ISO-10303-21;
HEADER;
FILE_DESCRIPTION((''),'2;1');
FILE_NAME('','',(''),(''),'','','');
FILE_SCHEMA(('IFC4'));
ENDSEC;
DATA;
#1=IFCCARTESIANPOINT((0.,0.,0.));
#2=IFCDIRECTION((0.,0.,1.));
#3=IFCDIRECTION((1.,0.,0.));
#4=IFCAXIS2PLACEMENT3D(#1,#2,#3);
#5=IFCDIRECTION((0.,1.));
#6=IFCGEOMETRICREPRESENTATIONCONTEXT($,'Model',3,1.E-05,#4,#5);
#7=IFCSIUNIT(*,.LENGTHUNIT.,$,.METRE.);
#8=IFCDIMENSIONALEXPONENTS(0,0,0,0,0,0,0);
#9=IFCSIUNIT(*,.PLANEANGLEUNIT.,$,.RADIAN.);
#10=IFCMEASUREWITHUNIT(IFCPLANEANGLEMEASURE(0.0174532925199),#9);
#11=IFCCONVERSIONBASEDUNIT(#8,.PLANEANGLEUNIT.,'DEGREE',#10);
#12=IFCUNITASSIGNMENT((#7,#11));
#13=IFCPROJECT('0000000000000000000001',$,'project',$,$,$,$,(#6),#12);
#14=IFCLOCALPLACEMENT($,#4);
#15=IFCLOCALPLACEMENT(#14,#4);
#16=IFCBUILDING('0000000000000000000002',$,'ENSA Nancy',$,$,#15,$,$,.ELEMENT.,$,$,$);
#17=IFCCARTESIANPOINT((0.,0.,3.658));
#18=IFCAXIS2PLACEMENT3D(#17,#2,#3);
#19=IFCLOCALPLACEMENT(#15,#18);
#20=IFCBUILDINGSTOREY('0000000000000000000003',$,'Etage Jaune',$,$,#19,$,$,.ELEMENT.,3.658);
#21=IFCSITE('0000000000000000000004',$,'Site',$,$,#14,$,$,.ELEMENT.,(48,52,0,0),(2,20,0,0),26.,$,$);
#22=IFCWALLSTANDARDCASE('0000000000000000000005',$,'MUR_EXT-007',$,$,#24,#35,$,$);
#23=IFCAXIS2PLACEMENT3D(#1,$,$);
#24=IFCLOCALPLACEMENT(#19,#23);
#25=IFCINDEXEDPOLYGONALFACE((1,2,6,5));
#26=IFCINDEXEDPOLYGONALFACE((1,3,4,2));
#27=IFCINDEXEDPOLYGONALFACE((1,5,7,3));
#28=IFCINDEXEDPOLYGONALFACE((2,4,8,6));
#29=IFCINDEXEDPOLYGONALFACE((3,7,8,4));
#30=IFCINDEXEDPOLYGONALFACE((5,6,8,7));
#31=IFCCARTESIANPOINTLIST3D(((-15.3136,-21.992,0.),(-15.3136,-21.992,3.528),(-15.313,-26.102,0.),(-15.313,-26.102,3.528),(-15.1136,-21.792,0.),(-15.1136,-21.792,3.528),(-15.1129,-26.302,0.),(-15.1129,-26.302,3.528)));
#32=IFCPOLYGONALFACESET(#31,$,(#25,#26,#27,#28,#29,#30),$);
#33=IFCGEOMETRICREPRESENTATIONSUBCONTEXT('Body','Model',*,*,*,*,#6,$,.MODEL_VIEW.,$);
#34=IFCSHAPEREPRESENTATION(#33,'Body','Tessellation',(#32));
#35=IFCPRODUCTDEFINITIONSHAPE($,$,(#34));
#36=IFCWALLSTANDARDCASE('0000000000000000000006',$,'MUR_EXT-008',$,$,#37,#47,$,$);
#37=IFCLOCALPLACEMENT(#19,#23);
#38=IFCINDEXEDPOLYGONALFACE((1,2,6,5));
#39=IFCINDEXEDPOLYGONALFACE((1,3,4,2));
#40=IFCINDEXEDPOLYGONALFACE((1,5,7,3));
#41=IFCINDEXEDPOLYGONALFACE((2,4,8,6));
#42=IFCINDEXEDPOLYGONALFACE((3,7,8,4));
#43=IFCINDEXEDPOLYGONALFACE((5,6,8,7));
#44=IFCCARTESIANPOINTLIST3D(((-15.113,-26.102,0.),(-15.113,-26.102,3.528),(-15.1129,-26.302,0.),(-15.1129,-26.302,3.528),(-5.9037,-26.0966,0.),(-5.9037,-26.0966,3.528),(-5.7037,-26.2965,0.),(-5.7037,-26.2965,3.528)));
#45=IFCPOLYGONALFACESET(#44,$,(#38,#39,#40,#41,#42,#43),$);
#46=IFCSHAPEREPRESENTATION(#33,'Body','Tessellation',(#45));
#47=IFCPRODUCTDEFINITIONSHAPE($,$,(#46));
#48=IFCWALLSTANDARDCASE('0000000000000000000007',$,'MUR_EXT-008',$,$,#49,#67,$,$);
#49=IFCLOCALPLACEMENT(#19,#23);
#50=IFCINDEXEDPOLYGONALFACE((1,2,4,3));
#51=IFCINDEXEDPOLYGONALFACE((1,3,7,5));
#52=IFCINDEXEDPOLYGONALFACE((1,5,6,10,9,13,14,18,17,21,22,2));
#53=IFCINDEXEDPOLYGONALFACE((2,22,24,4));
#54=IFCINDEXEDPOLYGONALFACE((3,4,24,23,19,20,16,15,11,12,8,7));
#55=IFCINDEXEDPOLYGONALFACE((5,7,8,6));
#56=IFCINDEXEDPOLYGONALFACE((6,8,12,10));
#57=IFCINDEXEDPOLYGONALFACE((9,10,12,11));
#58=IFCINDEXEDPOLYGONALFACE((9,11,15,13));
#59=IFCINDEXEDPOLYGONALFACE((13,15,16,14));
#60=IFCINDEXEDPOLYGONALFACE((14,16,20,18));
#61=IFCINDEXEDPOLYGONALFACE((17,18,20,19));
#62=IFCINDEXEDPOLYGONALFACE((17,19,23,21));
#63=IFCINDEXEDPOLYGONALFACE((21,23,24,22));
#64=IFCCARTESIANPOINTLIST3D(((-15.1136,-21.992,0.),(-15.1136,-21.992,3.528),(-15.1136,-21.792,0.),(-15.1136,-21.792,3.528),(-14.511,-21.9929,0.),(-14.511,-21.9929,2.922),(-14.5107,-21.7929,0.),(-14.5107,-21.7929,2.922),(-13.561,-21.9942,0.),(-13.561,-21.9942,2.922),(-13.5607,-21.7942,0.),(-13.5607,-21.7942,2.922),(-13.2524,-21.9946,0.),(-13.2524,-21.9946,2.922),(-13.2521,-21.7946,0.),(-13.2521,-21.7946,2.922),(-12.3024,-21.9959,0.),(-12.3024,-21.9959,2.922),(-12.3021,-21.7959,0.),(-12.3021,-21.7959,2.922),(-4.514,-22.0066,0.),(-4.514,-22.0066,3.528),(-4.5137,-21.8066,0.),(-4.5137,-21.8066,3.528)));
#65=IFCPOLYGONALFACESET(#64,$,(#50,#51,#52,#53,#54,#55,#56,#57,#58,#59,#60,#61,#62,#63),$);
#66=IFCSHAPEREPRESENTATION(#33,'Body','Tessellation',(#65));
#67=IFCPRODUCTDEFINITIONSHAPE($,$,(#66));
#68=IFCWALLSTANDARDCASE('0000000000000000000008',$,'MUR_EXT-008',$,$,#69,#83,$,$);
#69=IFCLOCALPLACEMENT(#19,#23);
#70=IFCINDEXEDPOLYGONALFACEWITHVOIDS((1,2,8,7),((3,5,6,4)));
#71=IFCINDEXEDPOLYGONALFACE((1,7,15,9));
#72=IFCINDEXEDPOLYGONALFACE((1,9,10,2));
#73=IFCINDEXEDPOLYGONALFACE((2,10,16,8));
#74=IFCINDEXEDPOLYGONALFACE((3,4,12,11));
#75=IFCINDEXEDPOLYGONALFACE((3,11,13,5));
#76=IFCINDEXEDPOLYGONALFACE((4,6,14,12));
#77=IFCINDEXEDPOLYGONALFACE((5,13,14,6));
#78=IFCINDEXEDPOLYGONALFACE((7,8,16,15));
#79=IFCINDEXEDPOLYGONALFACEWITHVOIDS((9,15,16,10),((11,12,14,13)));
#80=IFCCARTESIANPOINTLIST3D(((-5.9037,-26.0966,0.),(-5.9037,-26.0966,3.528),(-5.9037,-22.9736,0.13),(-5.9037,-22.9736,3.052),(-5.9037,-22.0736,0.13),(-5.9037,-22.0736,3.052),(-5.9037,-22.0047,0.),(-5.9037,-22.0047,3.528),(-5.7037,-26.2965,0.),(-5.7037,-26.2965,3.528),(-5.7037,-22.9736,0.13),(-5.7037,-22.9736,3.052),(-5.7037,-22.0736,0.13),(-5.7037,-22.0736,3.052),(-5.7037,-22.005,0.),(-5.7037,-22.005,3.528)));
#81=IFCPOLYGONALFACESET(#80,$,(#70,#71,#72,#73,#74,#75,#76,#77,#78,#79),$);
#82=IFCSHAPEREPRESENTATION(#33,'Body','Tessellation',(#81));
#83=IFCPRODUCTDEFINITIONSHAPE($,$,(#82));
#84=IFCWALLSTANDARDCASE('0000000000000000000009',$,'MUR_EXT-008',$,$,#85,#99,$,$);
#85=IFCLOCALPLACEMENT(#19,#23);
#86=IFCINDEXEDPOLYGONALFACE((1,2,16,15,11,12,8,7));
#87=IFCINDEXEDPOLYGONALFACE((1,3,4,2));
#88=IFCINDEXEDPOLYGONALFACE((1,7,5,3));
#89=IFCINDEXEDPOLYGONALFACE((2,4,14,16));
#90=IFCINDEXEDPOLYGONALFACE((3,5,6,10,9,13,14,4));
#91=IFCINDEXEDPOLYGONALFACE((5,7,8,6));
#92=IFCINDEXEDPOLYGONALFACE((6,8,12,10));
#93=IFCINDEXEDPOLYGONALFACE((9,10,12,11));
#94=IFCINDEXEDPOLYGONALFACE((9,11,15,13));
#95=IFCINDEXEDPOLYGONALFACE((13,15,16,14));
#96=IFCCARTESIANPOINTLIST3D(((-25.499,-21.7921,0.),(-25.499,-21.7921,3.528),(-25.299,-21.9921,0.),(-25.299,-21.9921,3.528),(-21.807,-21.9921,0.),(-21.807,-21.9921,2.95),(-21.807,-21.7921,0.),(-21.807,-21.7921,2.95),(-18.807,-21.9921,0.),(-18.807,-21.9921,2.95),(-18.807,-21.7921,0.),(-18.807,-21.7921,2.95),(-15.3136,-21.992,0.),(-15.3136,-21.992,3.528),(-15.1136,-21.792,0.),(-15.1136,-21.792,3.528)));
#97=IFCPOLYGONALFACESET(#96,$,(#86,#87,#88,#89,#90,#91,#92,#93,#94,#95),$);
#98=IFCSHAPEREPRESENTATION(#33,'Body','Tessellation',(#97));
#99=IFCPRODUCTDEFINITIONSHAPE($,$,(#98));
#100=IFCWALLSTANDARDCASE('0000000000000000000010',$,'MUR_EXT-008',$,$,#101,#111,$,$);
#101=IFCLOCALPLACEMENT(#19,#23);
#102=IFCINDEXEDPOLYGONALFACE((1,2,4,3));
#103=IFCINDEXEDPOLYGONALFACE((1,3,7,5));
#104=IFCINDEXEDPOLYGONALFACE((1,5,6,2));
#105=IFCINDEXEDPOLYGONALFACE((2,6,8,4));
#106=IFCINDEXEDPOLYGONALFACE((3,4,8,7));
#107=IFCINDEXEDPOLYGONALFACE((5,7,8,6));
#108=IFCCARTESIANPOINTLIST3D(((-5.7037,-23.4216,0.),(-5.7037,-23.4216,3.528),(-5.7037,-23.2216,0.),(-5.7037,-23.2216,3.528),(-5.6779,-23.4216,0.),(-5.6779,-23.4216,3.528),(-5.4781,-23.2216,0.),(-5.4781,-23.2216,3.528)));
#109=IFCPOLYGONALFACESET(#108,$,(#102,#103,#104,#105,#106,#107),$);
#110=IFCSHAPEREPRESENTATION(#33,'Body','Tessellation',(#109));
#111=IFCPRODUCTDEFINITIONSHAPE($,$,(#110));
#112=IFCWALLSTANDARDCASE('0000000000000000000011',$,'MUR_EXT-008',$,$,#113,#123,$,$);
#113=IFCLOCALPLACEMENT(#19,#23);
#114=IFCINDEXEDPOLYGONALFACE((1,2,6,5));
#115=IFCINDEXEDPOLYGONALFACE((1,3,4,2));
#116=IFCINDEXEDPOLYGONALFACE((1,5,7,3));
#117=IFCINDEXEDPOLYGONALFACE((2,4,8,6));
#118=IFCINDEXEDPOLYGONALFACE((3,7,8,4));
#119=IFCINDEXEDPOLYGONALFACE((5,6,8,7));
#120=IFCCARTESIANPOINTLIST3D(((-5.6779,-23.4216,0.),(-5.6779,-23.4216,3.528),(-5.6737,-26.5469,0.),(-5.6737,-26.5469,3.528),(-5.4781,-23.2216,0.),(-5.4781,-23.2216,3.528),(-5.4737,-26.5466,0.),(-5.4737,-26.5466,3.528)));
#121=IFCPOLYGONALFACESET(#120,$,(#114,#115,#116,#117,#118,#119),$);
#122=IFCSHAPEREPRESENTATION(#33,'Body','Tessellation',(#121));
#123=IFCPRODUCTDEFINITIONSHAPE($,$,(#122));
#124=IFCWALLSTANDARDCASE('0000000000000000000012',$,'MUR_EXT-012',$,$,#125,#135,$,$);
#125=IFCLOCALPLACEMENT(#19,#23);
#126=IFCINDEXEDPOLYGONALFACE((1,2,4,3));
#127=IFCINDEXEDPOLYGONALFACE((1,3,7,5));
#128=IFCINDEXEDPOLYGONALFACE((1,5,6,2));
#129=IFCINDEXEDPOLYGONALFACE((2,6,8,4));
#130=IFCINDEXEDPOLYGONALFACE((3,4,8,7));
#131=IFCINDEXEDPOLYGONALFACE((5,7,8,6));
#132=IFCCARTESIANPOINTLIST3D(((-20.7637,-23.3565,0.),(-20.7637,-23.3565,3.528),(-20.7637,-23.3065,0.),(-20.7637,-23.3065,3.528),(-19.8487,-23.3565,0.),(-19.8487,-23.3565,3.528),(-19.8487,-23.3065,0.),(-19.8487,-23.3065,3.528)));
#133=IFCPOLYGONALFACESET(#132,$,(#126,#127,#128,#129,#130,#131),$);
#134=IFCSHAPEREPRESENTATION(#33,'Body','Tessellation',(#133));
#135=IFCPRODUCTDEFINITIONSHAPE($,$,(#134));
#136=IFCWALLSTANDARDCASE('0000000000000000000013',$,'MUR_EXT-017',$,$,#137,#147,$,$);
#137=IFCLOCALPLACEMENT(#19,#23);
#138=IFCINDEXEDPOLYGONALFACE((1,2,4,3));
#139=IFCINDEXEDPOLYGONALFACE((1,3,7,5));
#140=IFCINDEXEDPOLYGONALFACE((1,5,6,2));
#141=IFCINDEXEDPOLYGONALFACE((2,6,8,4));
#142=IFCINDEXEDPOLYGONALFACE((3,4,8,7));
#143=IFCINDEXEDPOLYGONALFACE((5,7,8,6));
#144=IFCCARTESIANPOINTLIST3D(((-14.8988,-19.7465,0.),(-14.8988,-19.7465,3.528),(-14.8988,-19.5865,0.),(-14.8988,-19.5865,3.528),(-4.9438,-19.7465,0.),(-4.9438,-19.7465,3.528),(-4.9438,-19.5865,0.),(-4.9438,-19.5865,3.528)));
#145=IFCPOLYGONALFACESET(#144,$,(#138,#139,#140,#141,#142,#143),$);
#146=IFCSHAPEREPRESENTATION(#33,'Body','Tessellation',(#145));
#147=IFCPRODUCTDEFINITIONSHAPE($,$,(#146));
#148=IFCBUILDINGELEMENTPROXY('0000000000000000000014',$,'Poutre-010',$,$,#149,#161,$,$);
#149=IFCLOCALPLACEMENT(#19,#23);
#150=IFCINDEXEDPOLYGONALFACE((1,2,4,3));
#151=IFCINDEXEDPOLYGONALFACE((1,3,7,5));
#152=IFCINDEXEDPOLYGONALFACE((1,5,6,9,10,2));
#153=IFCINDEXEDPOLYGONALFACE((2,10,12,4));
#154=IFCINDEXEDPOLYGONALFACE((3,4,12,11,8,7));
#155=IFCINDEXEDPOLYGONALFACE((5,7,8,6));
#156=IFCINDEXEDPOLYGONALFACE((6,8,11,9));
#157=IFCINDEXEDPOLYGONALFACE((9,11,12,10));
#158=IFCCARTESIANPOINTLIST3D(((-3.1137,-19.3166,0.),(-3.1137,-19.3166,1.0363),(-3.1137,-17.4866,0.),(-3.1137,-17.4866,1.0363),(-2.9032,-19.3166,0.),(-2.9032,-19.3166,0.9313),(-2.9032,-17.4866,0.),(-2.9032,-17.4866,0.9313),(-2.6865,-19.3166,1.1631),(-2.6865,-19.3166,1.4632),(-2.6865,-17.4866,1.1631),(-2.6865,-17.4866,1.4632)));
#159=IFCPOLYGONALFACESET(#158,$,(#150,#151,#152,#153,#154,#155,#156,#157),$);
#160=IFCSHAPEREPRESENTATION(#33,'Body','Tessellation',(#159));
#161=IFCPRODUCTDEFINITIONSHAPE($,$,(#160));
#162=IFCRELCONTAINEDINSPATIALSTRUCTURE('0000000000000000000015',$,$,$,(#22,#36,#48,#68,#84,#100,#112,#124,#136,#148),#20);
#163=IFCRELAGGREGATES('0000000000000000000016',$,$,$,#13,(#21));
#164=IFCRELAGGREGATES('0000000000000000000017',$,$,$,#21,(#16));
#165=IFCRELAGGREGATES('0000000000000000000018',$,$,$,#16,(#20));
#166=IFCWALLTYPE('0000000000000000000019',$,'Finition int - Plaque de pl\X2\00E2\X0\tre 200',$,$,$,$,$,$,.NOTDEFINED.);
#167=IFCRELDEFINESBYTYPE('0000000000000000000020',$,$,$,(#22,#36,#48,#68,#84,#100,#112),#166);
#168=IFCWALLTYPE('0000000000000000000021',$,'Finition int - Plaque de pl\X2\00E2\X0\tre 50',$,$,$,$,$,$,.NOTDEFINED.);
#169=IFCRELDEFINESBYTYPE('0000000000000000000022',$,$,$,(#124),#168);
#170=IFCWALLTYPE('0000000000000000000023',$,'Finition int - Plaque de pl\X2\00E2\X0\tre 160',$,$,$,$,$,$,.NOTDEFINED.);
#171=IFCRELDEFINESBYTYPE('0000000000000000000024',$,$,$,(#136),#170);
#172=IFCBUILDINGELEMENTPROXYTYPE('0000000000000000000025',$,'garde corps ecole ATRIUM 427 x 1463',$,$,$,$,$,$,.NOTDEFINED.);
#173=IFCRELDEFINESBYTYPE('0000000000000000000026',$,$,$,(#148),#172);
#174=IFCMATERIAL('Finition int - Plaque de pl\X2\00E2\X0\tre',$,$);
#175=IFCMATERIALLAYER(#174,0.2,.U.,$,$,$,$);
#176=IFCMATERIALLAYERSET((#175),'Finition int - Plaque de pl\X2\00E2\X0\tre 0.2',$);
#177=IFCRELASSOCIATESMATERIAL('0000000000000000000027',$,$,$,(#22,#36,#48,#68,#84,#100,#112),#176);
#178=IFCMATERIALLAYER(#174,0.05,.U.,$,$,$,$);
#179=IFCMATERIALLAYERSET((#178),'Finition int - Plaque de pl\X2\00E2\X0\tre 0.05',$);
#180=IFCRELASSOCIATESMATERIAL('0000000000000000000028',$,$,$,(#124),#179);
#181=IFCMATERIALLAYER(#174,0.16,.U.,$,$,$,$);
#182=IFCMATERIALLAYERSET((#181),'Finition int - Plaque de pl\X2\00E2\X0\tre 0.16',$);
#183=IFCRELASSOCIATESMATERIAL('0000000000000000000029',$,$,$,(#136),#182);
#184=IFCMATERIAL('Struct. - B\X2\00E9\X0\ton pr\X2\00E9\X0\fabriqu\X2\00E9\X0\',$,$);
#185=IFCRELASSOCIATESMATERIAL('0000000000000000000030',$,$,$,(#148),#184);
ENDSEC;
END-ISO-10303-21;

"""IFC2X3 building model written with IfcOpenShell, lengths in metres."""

from ifc_helpers import new_model, entity, si_unit, converted_unit, direction, frame, origin_with_axes, origin_2d_with_axis, place, context, subcontext, project, spatial, polyline, rectangle, outline, extrude, material, layer, layer_set, layer_usage, type_object, element, save


model = new_model("IFC2X3")

# Units and contexts
model_context = context("Model", 3, precision=1e-05, world=origin_with_axes(), true_north=direction((0.0, 1.0)))
body_context = subcontext(model_context, "Body", "Model", "MODEL_VIEW")
ifc_project = project(units=[si_unit("LENGTHUNIT", "METRE"), converted_unit("PLANEANGLEUNIT", "DEGREE", entity("IfcPlaneAngleMeasure", 0.0174532925199), si_unit("PLANEANGLEUNIT", "RADIAN"), dimensions=[0, 0, 0, 0, 0, 0, 0])], contexts=[model_context])

# Site, building, storey
site_placement = place(None, origin_with_axes())
site = spatial("IfcSite", under=ifc_project, at=site_placement, Name="Site", CompositionType="ELEMENT", RefLatitude=(48, 52, 0, 0), RefLongitude=(2, 20, 0, 0), RefElevation=26.0)
building_placement = place(site_placement, origin_with_axes())
building = spatial("IfcBuilding", under=site, at=building_placement, Name="ENSA Nancy", CompositionType="ELEMENT")
storey_placement = place(building_placement, frame((0.0, 0.0, 3.658), z_axis=(0.0, 0.0, 1.0), x_axis=(1.0, 0.0, 0.0)))
storey = spatial("IfcBuildingStorey", under=building, at=storey_placement, Name="Etage Jaune", CompositionType="ELEMENT", Elevation=3.658)

# Walls
ifc_material_1 = material(Name="Finition int - Plaque de plâtre")
ifc_layer_1 = layer(ifc_material_1, 0.2, ventilated="UNKNOWN")
ifc_layer_set_1 = layer_set([ifc_layer_1], Name="Finition int - Plaque de plâtre 0.2")
ifc_layer_usage_1 = layer_usage(ifc_layer_set_1, "AXIS2", "POSITIVE", 0.0)
wall_type_1 = type_object("IfcWallType", Name="Finition int - Plaque de plâtre 200", PredefinedType="NOTDEFINED")
wall_1_placement = place(storey_placement, frame((-15.1129, -26.302, 0.0), z_axis=(0.0, 0.0, 1.0), x_axis=(-0.00015, 1.0, 0.0)))
element("IfcWallStandardCase", 1, at=wall_1_placement, inside=storey, type_object=wall_type_1, material=ifc_layer_usage_1, Name="MUR_EXT-007", context=body_context, shape_type="SweptSolid", body=[
    extrude(outline(polyline([(0.0, 0.0), (4.51, 0.0), (4.31, 0.2), (0.2, 0.2), (0.0, 0.0)])), origin_with_axes(), (0.0, 0.0, 1.0), 3.528),
])
ifc_layer_usage_2 = layer_usage(ifc_layer_set_1, "AXIS2", "NEGATIVE", 0.0)
wall_2_placement = place(storey_placement, frame((-5.7037, -26.2965, 0.0), z_axis=(0.0, 0.0, 1.0), x_axis=(-1.0, -0.000589, 0.0)))
element("IfcWallStandardCase", 2, at=wall_2_placement, inside=storey, type_object=wall_type_1, material=ifc_layer_usage_2, Name="MUR_EXT-008", context=body_context, shape_type="SweptSolid", body=[
    extrude(outline(polyline([(0.1999, -0.2), (9.4092, -0.2), (9.4092, 0.0), (0.0, 0.0), (0.1999, -0.2)])), origin_with_axes(), (0.0, 0.0, 1.0), 3.528),
])

# Wall, openings
ifc_layer_usage_3 = layer_usage(ifc_layer_set_1, "AXIS2", "POSITIVE", 0.0)
wall_3_placement = place(storey_placement, frame((-4.5137, -21.8066, 0.0), z_axis=(0.0, 0.0, 1.0), x_axis=(-0.999999, 0.001372, 0.0)))
wall_3 = element("IfcWallStandardCase", 3, at=wall_3_placement, inside=storey, type_object=wall_type_1, material=ifc_layer_usage_3, Name="MUR_EXT-008", context=body_context, shape_type="SweptSolid", body=[
    extrude(outline(polyline([(0.0, 0.0), (10.5999, 0.0), (10.5996, 0.2), (0.0, 0.2), (0.0, 0.0)])), origin_with_axes(), (0.0, 0.0, 1.0), 3.528),
])
opening_1_placement = place(wall_3_placement, frame((8.2634, 0.0, 0.0), z_axis=(0.0, 0.0, 1.0), x_axis=(1.0, 0.0, 0.0)))
element("IfcOpeningElement", 4, at=opening_1_placement, cuts=wall_3, context=body_context, shape_type="SweptSolid", body=[
    extrude(rectangle(XDim=0.95, YDim=2.922, at=origin_2d_with_axis()), frame((0.0, 0.2, 1.461), z_axis=(0.0, 1.0, 0.0), x_axis=(1.0, 0.0, 0.0)), (0.0, 0.0, -1.0), 0.6),
])
opening_2_placement = place(wall_3_placement, frame((9.522, 0.0, 0.0), z_axis=(0.0, 0.0, 1.0), x_axis=(1.0, 0.0, 0.0)))
element("IfcOpeningElement", 5, at=opening_2_placement, cuts=wall_3, context=body_context, shape_type="SweptSolid", body=[
    extrude(rectangle(XDim=0.95, YDim=2.922, at=origin_2d_with_axis()), frame((0.0, 0.2, 1.461), z_axis=(0.0, -1.0, 0.0), x_axis=(-1.0, 0.0, 0.0)), (0.0, 0.0, 1.0), 0.6),
])

# Walls, openings
ifc_layer_usage_4 = layer_usage(ifc_layer_set_1, "AXIS2", "NEGATIVE", 0.0)
wall_4_placement = place(storey_placement, frame((-5.7037, -21.805, 0.0), z_axis=(0.0, 0.0, 1.0), x_axis=(0.0, -1.0, 0.0)))
wall_4 = element("IfcWallStandardCase", 6, at=wall_4_placement, inside=storey, type_object=wall_type_1, material=ifc_layer_usage_4, Name="MUR_EXT-008", context=body_context, shape_type="SweptSolid", body=[
    extrude(outline(polyline([(0.1997, -0.2), (4.2917, -0.2), (4.4915, 0.0), (0.2, 0.0), (0.1997, -0.2)])), origin_with_axes(), (0.0, 0.0, 1.0), 3.528),
])
opening_3_placement = place(wall_4_placement, frame((0.7186, 0.0, 0.13), z_axis=(0.0, 0.0, 1.0), x_axis=(1.0, 0.0, 0.0)))
element("IfcOpeningElement", 7, at=opening_3_placement, cuts=wall_4, context=body_context, shape_type="SweptSolid", body=[
    extrude(rectangle(XDim=0.9, YDim=2.922, at=origin_2d_with_axis()), frame((0.0, -0.2, 1.461), z_axis=(0.0, 1.0, 0.0), x_axis=(-1.0, 0.0, 0.0)), (0.0, 0.0, 1.0), 0.6),
])
ifc_layer_usage_5 = layer_usage(ifc_layer_set_1, "AXIS2", "POSITIVE", 0.0)
wall_5_placement = place(storey_placement, frame((-15.1136, -21.792, 0.0), z_axis=(0.0, 0.0, 1.0), x_axis=(-1.0, -0.000003, 0.0)))
wall_5 = element("IfcWallStandardCase", 8, at=wall_5_placement, inside=storey, type_object=wall_type_1, material=ifc_layer_usage_5, Name="MUR_EXT-008", context=body_context, shape_type="SweptSolid", body=[
    extrude(outline(polyline([(0.0, 0.0), (10.3854, 0.0), (10.1854, 0.2), (0.2, 0.2), (0.0, 0.0)])), origin_with_axes(), (0.0, 0.0, 1.0), 3.528),
])
opening_4_placement = place(wall_5_placement, frame((5.1934, 0.0, 0.0), z_axis=(0.0, 0.0, 1.0), x_axis=(1.0, 0.0, 0.0)))
element("IfcOpeningElement", 9, at=opening_4_placement, cuts=wall_5, context=body_context, shape_type="SweptSolid", body=[
    extrude(rectangle(XDim=3.0, YDim=2.95, at=origin_2d_with_axis()), frame((0.0, 0.2, 1.475), z_axis=(0.0, 1.0, 0.0), x_axis=(-1.0, 0.0, 0.0)), (0.0, 0.0, -1.0), 0.6),
])

# Walls
ifc_layer_usage_6 = layer_usage(ifc_layer_set_1, "AXIS2", "NEGATIVE", 0.0)
wall_6_placement = place(storey_placement, frame((-5.7037, -23.2216, 0.0), z_axis=(0.0, 0.0, 1.0), x_axis=(1.0, 0.0, 0.0)))
element("IfcWallStandardCase", 10, at=wall_6_placement, inside=storey, type_object=wall_type_1, material=ifc_layer_usage_6, Name="MUR_EXT-008", context=body_context, shape_type="SweptSolid", body=[
    extrude(outline(polyline([(0.0, -0.2), (0.0258, -0.2), (0.2255, 0.0), (0.0, 0.0), (0.0, -0.2)])), origin_with_axes(), (0.0, 0.0, 1.0), 3.528),
])
ifc_layer_usage_7 = layer_usage(ifc_layer_set_1, "AXIS2", "NEGATIVE", 0.0)
wall_7_placement = place(storey_placement, frame((-5.4781, -23.2216, 0.0), z_axis=(0.0, 0.0, 1.0), x_axis=(0.001341, -0.999999, 0.0)))
element("IfcWallStandardCase", 11, at=wall_7_placement, inside=storey, type_object=wall_type_1, material=ifc_layer_usage_7, Name="MUR_EXT-008", context=body_context, shape_type="SweptSolid", body=[
    extrude(outline(polyline([(0.1997, -0.2), (3.325, -0.2), (3.325, 0.0), (0.0, 0.0), (0.1997, -0.2)])), origin_with_axes(), (0.0, 0.0, 1.0), 3.528),
])
ifc_layer_2 = layer(ifc_material_1, 0.05, ventilated="UNKNOWN")
ifc_layer_set_2 = layer_set([ifc_layer_2], Name="Finition int - Plaque de plâtre 0.05")
ifc_layer_usage_8 = layer_usage(ifc_layer_set_2, "AXIS2", "POSITIVE", -0.05)
wall_type_2 = type_object("IfcWallType", Name="Finition int - Plaque de plâtre 50", PredefinedType="NOTDEFINED")
wall_8_placement = place(storey_placement, frame((-19.8487, -23.3565, 0.0), z_axis=(0.0, 0.0, 1.0), x_axis=(-1.0, 0.0, 0.0)))
element("IfcWallStandardCase", 12, at=wall_8_placement, inside=storey, type_object=wall_type_2, material=ifc_layer_usage_8, Name="MUR_EXT-012", context=body_context, shape_type="SweptSolid", body=[
    extrude(outline(polyline([(0.0, -0.05), (0.915, -0.05), (0.915, 0.0), (0.0, 0.0), (0.0, -0.05)])), origin_with_axes(), (0.0, 0.0, 1.0), 3.528),
])
ifc_layer_3 = layer(ifc_material_1, 0.16, ventilated="UNKNOWN")
ifc_layer_set_3 = layer_set([ifc_layer_3], Name="Finition int - Plaque de plâtre 0.16")
ifc_layer_usage_9 = layer_usage(ifc_layer_set_3, "AXIS2", "POSITIVE", -0.16)
wall_type_3 = type_object("IfcWallType", Name="Finition int - Plaque de plâtre 160", PredefinedType="NOTDEFINED")
wall_9_placement = place(storey_placement, frame((-14.8988, -19.5865, 0.0), z_axis=(0.0, 0.0, 1.0), x_axis=(1.0, 0.0, 0.0)))
element("IfcWallStandardCase", 13, at=wall_9_placement, inside=storey, type_object=wall_type_3, material=ifc_layer_usage_9, Name="MUR_EXT-017", context=body_context, shape_type="SweptSolid", body=[
    extrude(outline(polyline([(0.0, -0.16), (9.955, -0.16), (9.955, 0.0), (0.0, 0.0), (0.0, -0.16)])), origin_with_axes(), (0.0, 0.0, 1.0), 3.528),
])

# Building element proxy
ifc_material_2 = material(Name="Struct. - Béton préfabriqué")
building_element_proxy_type_1 = type_object("IfcBuildingElementProxyType", Name="garde corps ecole ATRIUM 427 x 1463", PredefinedType="NOTDEFINED")
proxy_1_placement = place(storey_placement, frame((-3.1137, -19.3166, 0.0), z_axis=(0.0, 0.0, 1.0), x_axis=(1.0, 0.0, 0.0)))
element("IfcBuildingElementProxy", 14, at=proxy_1_placement, inside=storey, type_object=building_element_proxy_type_1, material=ifc_material_2, Name="Poutre-010", context=body_context, shape_type="SweptSolid", body=[
    extrude(outline(polyline([(0.0, 1.0363), (0.0, 0.0), (0.2105, 0.0), (0.2105, 0.9313), (0.4272, 1.1631), (0.4272, 1.4632), (0.0, 1.0363)])), frame((0.0, 1.83, 0.0), z_axis=(0.0, -1.0, 0.0), x_axis=(1.0, 0.0, 0.0)), (0.0, 0.0, 1.0), 1.83),
])

save(model, "model.ifc")
